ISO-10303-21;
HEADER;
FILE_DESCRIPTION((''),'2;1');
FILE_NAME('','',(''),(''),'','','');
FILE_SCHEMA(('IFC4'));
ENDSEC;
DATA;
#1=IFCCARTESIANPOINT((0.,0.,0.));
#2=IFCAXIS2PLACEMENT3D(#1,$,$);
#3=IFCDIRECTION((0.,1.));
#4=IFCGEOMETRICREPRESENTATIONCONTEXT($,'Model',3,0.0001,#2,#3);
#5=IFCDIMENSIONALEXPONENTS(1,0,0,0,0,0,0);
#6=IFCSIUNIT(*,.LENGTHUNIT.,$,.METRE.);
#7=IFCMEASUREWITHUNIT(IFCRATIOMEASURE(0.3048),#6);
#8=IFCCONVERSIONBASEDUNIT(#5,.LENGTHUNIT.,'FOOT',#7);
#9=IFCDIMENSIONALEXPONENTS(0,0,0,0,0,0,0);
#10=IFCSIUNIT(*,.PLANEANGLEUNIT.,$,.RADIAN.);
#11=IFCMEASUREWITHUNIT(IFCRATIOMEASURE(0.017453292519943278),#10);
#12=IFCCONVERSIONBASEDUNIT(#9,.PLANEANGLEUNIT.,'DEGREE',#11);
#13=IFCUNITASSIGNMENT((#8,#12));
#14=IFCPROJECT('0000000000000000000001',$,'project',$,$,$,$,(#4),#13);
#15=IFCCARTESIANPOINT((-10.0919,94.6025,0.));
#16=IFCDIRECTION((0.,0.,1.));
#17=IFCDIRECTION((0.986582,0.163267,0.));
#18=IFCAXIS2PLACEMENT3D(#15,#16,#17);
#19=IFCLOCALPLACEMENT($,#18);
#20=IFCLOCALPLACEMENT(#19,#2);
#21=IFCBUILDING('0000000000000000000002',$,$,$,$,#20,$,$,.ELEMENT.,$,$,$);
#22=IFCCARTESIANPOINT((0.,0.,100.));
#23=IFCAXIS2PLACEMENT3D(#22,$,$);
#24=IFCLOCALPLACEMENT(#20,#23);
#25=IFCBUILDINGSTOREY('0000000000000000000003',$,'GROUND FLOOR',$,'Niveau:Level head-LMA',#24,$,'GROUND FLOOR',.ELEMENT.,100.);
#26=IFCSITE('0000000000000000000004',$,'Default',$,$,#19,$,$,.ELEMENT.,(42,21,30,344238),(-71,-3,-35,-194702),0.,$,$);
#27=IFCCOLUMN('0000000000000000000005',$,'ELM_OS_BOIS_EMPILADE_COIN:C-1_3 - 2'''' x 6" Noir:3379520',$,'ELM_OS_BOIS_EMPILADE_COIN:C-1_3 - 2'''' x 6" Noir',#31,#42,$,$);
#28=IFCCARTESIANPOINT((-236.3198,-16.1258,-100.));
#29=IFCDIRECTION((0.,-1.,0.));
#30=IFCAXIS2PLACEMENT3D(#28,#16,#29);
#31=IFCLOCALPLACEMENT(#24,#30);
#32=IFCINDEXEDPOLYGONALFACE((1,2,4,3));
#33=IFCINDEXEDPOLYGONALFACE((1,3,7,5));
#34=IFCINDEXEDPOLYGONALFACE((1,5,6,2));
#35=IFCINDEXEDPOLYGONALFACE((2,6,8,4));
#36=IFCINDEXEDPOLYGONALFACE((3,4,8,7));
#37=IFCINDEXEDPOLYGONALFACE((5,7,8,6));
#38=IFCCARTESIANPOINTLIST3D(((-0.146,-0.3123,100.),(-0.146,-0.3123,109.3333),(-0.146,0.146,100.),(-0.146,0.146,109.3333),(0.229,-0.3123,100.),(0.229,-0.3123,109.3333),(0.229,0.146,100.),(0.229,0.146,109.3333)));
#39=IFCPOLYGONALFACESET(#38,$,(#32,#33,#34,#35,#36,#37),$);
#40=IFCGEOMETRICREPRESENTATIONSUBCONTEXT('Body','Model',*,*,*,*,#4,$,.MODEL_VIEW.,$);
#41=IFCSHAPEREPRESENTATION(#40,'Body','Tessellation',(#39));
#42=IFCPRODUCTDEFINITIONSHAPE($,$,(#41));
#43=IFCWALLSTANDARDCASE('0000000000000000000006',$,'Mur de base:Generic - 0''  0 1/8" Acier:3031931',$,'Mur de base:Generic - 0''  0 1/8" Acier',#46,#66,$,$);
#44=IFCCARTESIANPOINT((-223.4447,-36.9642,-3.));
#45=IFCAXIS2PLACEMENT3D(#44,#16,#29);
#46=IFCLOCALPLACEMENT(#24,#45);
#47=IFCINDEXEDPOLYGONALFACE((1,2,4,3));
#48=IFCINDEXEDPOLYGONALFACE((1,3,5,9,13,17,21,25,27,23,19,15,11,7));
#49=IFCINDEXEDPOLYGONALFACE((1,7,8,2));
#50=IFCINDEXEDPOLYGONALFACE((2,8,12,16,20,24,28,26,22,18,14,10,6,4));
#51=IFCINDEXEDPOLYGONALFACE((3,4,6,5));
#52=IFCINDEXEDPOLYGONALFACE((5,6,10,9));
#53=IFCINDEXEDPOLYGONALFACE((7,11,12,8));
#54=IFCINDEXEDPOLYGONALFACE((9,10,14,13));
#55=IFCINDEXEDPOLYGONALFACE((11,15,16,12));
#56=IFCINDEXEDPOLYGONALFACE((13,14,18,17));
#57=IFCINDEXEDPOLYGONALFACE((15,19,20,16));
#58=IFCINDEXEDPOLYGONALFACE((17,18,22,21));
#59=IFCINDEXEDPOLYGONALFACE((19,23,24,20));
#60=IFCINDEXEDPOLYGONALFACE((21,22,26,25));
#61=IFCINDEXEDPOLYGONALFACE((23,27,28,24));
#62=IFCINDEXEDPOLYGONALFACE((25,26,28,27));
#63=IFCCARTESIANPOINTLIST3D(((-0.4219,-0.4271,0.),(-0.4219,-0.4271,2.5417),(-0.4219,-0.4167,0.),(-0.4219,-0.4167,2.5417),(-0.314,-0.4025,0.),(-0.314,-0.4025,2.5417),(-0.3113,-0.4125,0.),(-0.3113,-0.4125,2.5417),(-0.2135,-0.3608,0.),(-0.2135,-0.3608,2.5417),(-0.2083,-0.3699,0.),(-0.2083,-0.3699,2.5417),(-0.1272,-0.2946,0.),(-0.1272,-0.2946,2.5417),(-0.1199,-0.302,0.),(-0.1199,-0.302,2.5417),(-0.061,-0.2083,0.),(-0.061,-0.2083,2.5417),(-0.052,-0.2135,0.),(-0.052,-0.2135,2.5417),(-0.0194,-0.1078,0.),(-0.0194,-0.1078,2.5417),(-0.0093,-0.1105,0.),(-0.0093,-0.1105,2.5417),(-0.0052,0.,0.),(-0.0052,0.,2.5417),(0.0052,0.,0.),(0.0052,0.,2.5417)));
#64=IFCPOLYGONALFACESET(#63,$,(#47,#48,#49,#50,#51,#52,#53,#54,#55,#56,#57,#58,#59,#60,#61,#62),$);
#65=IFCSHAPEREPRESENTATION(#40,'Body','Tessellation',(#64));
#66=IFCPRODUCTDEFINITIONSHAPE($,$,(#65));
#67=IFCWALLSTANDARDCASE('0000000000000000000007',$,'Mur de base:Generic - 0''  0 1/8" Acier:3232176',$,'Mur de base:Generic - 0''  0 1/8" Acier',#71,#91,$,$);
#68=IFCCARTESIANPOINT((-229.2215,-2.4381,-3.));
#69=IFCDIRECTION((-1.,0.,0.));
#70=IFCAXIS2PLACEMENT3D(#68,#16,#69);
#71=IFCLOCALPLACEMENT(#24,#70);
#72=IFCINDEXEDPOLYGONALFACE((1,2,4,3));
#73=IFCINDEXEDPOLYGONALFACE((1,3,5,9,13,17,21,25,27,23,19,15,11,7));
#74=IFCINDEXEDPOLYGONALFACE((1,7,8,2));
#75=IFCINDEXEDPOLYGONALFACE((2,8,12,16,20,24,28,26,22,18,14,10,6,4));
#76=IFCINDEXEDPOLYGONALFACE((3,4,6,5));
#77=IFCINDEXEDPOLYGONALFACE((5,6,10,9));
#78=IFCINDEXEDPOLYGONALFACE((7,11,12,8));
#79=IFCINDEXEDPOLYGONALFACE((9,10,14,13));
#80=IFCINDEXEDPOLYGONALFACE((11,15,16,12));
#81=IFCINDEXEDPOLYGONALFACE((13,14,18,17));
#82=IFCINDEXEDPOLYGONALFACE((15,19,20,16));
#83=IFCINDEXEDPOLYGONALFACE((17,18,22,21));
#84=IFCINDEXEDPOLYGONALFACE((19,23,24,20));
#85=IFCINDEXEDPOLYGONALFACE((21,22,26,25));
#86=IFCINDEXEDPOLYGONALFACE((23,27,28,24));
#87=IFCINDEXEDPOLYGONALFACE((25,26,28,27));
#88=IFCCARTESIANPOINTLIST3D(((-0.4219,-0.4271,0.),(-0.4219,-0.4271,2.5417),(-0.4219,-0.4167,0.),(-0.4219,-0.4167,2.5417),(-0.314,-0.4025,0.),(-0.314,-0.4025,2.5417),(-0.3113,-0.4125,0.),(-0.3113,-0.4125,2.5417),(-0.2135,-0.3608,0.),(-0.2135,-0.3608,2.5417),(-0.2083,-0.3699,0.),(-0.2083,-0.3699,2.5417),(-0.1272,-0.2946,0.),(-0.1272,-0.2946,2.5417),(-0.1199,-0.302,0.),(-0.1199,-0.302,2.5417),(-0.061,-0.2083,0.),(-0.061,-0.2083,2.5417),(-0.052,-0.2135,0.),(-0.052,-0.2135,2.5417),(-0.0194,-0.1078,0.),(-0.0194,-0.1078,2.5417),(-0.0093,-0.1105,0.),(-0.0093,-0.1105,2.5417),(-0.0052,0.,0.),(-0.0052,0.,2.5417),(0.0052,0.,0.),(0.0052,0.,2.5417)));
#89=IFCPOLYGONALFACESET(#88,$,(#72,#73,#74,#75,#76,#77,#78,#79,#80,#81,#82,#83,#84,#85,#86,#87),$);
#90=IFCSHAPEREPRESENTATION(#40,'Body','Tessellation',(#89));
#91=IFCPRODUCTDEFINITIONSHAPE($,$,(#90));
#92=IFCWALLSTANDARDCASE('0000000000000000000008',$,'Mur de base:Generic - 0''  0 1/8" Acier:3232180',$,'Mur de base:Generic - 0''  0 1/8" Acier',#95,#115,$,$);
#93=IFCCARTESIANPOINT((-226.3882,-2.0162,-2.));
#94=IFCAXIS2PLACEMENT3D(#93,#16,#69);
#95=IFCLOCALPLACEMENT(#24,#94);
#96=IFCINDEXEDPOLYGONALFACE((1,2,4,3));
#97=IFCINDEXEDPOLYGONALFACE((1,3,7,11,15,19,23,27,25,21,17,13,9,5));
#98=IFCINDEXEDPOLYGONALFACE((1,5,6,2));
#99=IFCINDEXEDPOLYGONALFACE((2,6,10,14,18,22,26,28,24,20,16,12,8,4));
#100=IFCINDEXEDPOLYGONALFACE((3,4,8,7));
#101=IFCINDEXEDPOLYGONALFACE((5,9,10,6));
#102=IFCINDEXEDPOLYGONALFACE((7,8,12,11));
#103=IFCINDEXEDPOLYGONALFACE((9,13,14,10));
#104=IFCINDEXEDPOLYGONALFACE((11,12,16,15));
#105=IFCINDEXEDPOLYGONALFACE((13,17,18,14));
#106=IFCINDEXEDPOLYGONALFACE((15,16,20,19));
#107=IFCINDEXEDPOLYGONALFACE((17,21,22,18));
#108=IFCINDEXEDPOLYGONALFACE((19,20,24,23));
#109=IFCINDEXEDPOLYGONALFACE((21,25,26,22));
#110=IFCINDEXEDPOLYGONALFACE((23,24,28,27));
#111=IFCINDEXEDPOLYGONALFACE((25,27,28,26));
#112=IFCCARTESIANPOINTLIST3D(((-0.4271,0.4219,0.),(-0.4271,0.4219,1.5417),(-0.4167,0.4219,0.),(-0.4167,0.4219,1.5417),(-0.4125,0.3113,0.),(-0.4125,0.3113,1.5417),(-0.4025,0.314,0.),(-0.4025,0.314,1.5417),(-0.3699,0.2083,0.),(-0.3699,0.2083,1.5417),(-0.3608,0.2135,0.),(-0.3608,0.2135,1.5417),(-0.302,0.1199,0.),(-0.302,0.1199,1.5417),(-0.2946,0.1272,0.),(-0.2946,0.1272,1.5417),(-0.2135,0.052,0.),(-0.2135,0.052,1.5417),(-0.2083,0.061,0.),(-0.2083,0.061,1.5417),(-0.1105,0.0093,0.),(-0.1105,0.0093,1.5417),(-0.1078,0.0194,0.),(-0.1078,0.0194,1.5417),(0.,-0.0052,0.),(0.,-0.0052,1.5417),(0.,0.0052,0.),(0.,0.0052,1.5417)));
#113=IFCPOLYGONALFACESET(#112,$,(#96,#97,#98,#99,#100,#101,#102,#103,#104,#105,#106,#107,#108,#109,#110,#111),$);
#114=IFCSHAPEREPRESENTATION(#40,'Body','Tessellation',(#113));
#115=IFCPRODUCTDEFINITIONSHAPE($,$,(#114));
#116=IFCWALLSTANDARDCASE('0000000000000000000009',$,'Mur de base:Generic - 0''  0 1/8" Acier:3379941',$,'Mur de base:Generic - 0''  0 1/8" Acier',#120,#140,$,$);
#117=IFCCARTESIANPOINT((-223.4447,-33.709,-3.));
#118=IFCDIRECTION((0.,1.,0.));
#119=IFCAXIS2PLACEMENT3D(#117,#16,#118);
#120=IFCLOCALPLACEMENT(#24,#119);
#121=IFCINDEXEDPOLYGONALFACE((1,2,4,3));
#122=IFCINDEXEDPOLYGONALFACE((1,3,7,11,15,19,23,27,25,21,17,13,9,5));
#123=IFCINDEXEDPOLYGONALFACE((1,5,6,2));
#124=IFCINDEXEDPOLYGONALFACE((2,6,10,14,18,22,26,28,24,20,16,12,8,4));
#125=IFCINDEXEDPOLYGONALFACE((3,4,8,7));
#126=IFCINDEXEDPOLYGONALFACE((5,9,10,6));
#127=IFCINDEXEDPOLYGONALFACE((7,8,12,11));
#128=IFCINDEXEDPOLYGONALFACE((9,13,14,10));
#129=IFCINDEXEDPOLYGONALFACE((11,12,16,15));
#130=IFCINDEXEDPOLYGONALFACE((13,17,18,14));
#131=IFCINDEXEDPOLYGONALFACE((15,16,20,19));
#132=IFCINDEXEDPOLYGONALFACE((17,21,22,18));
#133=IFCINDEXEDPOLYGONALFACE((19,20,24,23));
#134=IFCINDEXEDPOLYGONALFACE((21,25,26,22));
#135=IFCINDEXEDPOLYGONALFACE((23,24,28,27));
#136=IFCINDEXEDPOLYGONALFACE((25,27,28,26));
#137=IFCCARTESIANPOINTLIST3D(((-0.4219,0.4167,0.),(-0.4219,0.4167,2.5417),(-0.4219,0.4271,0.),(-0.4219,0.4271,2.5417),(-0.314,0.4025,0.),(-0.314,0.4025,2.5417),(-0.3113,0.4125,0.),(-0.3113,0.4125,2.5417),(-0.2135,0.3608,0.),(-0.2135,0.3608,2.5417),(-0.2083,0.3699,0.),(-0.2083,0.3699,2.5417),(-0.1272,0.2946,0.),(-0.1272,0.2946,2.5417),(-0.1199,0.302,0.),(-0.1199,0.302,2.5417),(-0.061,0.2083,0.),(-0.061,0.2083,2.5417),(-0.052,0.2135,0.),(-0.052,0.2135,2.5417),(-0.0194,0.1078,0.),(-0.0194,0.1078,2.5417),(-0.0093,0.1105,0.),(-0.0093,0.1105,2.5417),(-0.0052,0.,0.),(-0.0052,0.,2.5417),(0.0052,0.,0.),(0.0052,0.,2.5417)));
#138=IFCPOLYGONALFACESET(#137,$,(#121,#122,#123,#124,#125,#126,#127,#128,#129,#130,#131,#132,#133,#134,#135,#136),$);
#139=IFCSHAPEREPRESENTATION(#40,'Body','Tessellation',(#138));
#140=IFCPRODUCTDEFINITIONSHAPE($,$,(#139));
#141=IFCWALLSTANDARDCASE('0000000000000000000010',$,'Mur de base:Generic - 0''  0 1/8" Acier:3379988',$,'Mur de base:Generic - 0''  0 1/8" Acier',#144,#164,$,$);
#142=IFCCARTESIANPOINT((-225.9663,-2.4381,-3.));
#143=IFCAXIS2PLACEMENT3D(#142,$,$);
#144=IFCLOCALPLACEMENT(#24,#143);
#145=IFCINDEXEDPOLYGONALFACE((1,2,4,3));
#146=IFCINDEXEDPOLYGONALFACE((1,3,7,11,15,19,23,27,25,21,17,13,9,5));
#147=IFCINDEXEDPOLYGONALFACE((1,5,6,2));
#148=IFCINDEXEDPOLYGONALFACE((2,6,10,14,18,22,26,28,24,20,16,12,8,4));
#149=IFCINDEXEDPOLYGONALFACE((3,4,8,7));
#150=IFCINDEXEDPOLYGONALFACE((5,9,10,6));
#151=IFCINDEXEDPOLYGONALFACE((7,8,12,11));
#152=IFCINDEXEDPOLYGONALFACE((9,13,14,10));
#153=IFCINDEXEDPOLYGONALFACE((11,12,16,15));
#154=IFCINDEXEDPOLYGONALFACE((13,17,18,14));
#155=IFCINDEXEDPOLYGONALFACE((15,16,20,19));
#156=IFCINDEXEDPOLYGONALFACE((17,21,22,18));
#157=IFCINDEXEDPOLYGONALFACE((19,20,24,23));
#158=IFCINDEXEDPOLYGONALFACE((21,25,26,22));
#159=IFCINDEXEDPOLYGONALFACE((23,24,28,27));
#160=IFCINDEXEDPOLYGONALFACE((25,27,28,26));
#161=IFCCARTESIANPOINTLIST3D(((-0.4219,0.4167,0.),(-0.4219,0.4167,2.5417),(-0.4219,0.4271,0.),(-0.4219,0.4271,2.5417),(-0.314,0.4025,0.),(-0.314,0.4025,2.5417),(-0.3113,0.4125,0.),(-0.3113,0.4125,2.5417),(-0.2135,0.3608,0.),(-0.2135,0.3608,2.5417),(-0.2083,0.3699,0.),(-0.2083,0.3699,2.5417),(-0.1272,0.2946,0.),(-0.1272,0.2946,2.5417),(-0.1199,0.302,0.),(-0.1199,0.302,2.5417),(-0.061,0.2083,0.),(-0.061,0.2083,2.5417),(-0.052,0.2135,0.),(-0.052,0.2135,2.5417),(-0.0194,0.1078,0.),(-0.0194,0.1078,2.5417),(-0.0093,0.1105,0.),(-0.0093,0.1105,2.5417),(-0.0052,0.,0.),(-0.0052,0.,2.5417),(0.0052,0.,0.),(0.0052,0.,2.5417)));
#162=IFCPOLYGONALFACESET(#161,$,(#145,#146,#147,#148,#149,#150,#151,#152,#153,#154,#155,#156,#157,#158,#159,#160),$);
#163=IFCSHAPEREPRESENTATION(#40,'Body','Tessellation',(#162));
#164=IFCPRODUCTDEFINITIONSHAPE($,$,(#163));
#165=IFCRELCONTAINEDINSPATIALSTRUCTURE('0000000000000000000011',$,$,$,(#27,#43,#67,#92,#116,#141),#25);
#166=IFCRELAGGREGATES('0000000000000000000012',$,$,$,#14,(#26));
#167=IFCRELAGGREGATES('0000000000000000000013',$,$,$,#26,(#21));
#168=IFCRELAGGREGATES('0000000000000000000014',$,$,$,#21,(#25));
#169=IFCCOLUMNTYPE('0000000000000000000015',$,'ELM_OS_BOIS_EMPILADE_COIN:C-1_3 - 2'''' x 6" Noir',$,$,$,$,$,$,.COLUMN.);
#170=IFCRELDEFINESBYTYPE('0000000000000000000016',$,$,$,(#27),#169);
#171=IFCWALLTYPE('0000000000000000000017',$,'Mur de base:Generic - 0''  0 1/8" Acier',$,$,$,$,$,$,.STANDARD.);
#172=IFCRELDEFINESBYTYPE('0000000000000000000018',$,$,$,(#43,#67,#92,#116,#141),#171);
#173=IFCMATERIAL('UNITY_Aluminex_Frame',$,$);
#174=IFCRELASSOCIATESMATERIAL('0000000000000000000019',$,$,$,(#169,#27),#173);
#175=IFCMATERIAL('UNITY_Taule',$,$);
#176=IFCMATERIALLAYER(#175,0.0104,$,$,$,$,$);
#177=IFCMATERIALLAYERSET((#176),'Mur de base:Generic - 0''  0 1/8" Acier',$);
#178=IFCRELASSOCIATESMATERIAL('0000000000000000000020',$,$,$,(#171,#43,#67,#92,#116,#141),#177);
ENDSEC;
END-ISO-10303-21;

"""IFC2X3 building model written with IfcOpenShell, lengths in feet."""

from ifc_helpers import new_model, entity, si_unit, converted_unit, direction, frame, frame_2d, origin, origin_2d_with_axis, place, context, subcontext, project, spatial, polyline, circle_curve, parameter, trimmed, segment, composite_curve, rectangle, outline, extrude, source, transform, mapped, material, layer, layer_set, layer_usage, type_object, type_shapes, element, save


model = new_model("IFC2X3")

# Units and contexts
model_context = context("Model", 3, precision=0.0001, world=origin(), true_north=direction((0.0, 1.0)))
body_context = subcontext(model_context, "Body", "Model", "MODEL_VIEW")
ifc_project = project(units=[converted_unit("LENGTHUNIT", "FOOT", entity("IfcRatioMeasure", 0.3048), si_unit("LENGTHUNIT", "METRE"), dimensions=[1, 0, 0, 0, 0, 0, 0]), converted_unit("PLANEANGLEUNIT", "DEGREE", entity("IfcRatioMeasure", 0.017453292519943278), si_unit("PLANEANGLEUNIT", "RADIAN"), dimensions=[0, 0, 0, 0, 0, 0, 0])], contexts=[model_context])

# Site, building, storey
site_placement = place(None, frame((-10.0919, 94.6025, 0.0), z_axis=(0.0, 0.0, 1.0), x_axis=(0.986582, 0.163267, 0.0)))
site = spatial("IfcSite", under=ifc_project, at=site_placement, Name="Default", CompositionType="ELEMENT", RefLatitude=(42, 21, 30, 344238), RefLongitude=(-71, -3, -35, -194702), RefElevation=0.0)
building_placement = place(site_placement, origin())
building = spatial("IfcBuilding", under=site, at=building_placement, CompositionType="ELEMENT")
storey_placement = place(building_placement, frame((0.0, 0.0, 100.0)))
storey = spatial("IfcBuildingStorey", under=building, at=storey_placement, Name="GROUND FLOOR", ObjectType="Niveau:Level head-LMA", LongName="GROUND FLOOR", CompositionType="ELEMENT", Elevation=100.0)

# Column
ifc_material_1 = material(Name="UNITY_Aluminex_Frame")
column_type = type_object("IfcColumnType", Name="ELM_OS_BOIS_EMPILADE_COIN:C-1_3 - 2'' x 6\" Noir", PredefinedType="COLUMN", material=ifc_material_1)
shared_shape = source(origin(), body_context, "Body", "SweptSolid", [
    extrude(rectangle(XDim=0.4583, YDim=0.375, at=origin_2d_with_axis()), frame((0.0415, -0.0832, 100.0), z_axis=(0.0, 0.0, 1.0), x_axis=(0.0, -1.0, 0.0)), (0.0, 0.0, 1.0), 9.3333),
])
type_shapes(column_type, [shared_shape])
column_placement = place(storey_placement, frame((-236.3198, -16.1258, -100.0), z_axis=(0.0, 0.0, 1.0), x_axis=(0.0, -1.0, 0.0)))
element("IfcColumn", 1, at=column_placement, inside=storey, type_object=column_type, material=ifc_material_1, Name="ELM_OS_BOIS_EMPILADE_COIN:C-1_3 - 2'' x 6\" Noir:3379520", ObjectType="ELM_OS_BOIS_EMPILADE_COIN:C-1_3 - 2'' x 6\" Noir", context=body_context, shape_type="MappedRepresentation", body=[
    mapped(shared_shape, transform((0.0, 0.0, 0.0), scale=1.0)),
])

# Walls
ifc_material_2 = material(Name="UNITY_Taule")
ifc_layer = layer(ifc_material_2, 0.0104)
ifc_layer_set = layer_set([ifc_layer], Name="Mur de base:Generic - 0'  0 1/8\" Acier")
ifc_layer_usage_1 = layer_usage(ifc_layer_set, "AXIS2", "NEGATIVE", 0.0052)
wall_type = type_object("IfcWallType", Name="Mur de base:Generic - 0'  0 1/8\" Acier", PredefinedType="STANDARD", material=ifc_layer_set)
wall_1_placement = place(storey_placement, frame((-223.4447, -36.9642, -3.0), z_axis=(0.0, 0.0, 1.0), x_axis=(0.0, -1.0, 0.0)))
element("IfcWallStandardCase", 2, at=wall_1_placement, inside=storey, type_object=wall_type, material=ifc_layer_usage_1, Name="Mur de base:Generic - 0'  0 1/8\" Acier:3031931", ObjectType="Mur de base:Generic - 0'  0 1/8\" Acier", context=body_context, shape_type="SweptSolid", body=[
    extrude(outline(composite_curve([segment(trimmed(circle_curve(frame_2d((-0.4219, 0.0), x_axis=(1.0, 0.0)), 0.4271), [parameter(270.0)], [parameter(0.0)], True, "PARAMETER"), True, "CONTINUOUS"), segment(polyline([(0.0052, 0.0), (-0.0052, 0.0)]), True, "CONTINUOUS"), segment(trimmed(circle_curve(frame_2d((-0.4219, 0.0), x_axis=(1.0, 0.0)), 0.4167), [parameter(270.0)], [parameter(0.0)], True, "PARAMETER"), False, "CONTINUOUS"), segment(polyline([(-0.4219, -0.4167), (-0.4219, -0.4271)]), True, "CONTINUOUS")], self_intersect=False)), origin(), (0.0, 0.0, 1.0), 2.5417),
])
ifc_layer_usage_2 = layer_usage(ifc_layer_set, "AXIS2", "NEGATIVE", 0.0052)
wall_2_placement = place(storey_placement, frame((-229.2215, -2.4381, -3.0), z_axis=(0.0, 0.0, 1.0), x_axis=(-1.0, 0.0, 0.0)))
element("IfcWallStandardCase", 3, at=wall_2_placement, inside=storey, type_object=wall_type, material=ifc_layer_usage_2, Name="Mur de base:Generic - 0'  0 1/8\" Acier:3232176", ObjectType="Mur de base:Generic - 0'  0 1/8\" Acier", context=body_context, shape_type="SweptSolid", body=[
    extrude(outline(composite_curve([segment(trimmed(circle_curve(frame_2d((-0.4219, 0.0), x_axis=(1.0, 0.0)), 0.4271), [parameter(270.0)], [parameter(0.0)], True, "PARAMETER"), True, "CONTINUOUS"), segment(polyline([(0.0052, 0.0), (-0.0052, 0.0)]), True, "CONTINUOUS"), segment(trimmed(circle_curve(frame_2d((-0.4219, 0.0), x_axis=(1.0, 0.0)), 0.4167), [parameter(270.0)], [parameter(0.0)], True, "PARAMETER"), False, "CONTINUOUS"), segment(polyline([(-0.4219, -0.4167), (-0.4219, -0.4271)]), True, "CONTINUOUS")], self_intersect=False)), origin(), (0.0, 0.0, 1.0), 2.5417),
])
ifc_layer_usage_3 = layer_usage(ifc_layer_set, "AXIS2", "NEGATIVE", 0.0052)
wall_3_placement = place(storey_placement, frame((-226.3882, -2.0162, -2.0), z_axis=(0.0, 0.0, 1.0), x_axis=(-1.0, 0.0, 0.0)))
element("IfcWallStandardCase", 4, at=wall_3_placement, inside=storey, type_object=wall_type, material=ifc_layer_usage_3, Name="Mur de base:Generic - 0'  0 1/8\" Acier:3232180", ObjectType="Mur de base:Generic - 0'  0 1/8\" Acier", context=body_context, shape_type="SweptSolid", body=[
    extrude(outline(composite_curve([segment(trimmed(circle_curve(frame_2d((0.0, 0.4219), x_axis=(1.0, 0.0)), 0.4271), [parameter(180.0)], [parameter(270.0)], True, "PARAMETER"), True, "CONTINUOUS"), segment(polyline([(0.0, -0.0052), (0.0, 0.0052)]), True, "CONTINUOUS"), segment(trimmed(circle_curve(frame_2d((0.0, 0.4219), x_axis=(1.0, 0.0)), 0.4167), [parameter(180.0)], [parameter(270.0)], True, "PARAMETER"), False, "CONTINUOUS"), segment(polyline([(-0.4167, 0.4219), (-0.4271, 0.4219)]), True, "CONTINUOUS")], self_intersect=False)), origin(), (0.0, 0.0, 1.0), 1.5417),
])
ifc_layer_usage_4 = layer_usage(ifc_layer_set, "AXIS2", "NEGATIVE", 0.0052)
wall_4_placement = place(storey_placement, frame((-223.4447, -33.709, -3.0), z_axis=(0.0, 0.0, 1.0), x_axis=(0.0, 1.0, 0.0)))
element("IfcWallStandardCase", 5, at=wall_4_placement, inside=storey, type_object=wall_type, material=ifc_layer_usage_4, Name="Mur de base:Generic - 0'  0 1/8\" Acier:3379941", ObjectType="Mur de base:Generic - 0'  0 1/8\" Acier", context=body_context, shape_type="SweptSolid", body=[
    extrude(outline(composite_curve([segment(trimmed(circle_curve(frame_2d((-0.4219, 0.0), x_axis=(1.0, 0.0)), 0.4167), [parameter(360.0)], [parameter(90.0)], True, "PARAMETER"), False, "CONTINUOUS"), segment(polyline([(-0.0052, 0.0), (0.0052, 0.0)]), True, "CONTINUOUS"), segment(trimmed(circle_curve(frame_2d((-0.4219, 0.0), x_axis=(1.0, 0.0)), 0.4271), [parameter(360.0)], [parameter(90.0)], True, "PARAMETER"), True, "CONTINUOUS"), segment(polyline([(-0.4219, 0.4271), (-0.4219, 0.4167)]), True, "CONTINUOUS")], self_intersect=False)), origin(), (0.0, 0.0, 1.0), 2.5417),
])
ifc_layer_usage_5 = layer_usage(ifc_layer_set, "AXIS2", "NEGATIVE", 0.0052)
wall_5_placement = place(storey_placement, frame((-225.9663, -2.4381, -3.0)))
element("IfcWallStandardCase", 6, at=wall_5_placement, inside=storey, type_object=wall_type, material=ifc_layer_usage_5, Name="Mur de base:Generic - 0'  0 1/8\" Acier:3379988", ObjectType="Mur de base:Generic - 0'  0 1/8\" Acier", context=body_context, shape_type="SweptSolid", body=[
    extrude(outline(composite_curve([segment(trimmed(circle_curve(frame_2d((-0.4219, 0.0), x_axis=(1.0, 0.0)), 0.4167), [parameter(360.0)], [parameter(90.0)], True, "PARAMETER"), False, "CONTINUOUS"), segment(polyline([(-0.0052, 0.0), (0.0052, 0.0)]), True, "CONTINUOUS"), segment(trimmed(circle_curve(frame_2d((-0.4219, 0.0), x_axis=(1.0, 0.0)), 0.4271), [parameter(360.0)], [parameter(90.0)], True, "PARAMETER"), True, "CONTINUOUS"), segment(polyline([(-0.4219, 0.4271), (-0.4219, 0.4167)]), True, "CONTINUOUS")], self_intersect=False)), origin(), (0.0, 0.0, 1.0), 2.5417),
])

save(model, "model.ifc")
